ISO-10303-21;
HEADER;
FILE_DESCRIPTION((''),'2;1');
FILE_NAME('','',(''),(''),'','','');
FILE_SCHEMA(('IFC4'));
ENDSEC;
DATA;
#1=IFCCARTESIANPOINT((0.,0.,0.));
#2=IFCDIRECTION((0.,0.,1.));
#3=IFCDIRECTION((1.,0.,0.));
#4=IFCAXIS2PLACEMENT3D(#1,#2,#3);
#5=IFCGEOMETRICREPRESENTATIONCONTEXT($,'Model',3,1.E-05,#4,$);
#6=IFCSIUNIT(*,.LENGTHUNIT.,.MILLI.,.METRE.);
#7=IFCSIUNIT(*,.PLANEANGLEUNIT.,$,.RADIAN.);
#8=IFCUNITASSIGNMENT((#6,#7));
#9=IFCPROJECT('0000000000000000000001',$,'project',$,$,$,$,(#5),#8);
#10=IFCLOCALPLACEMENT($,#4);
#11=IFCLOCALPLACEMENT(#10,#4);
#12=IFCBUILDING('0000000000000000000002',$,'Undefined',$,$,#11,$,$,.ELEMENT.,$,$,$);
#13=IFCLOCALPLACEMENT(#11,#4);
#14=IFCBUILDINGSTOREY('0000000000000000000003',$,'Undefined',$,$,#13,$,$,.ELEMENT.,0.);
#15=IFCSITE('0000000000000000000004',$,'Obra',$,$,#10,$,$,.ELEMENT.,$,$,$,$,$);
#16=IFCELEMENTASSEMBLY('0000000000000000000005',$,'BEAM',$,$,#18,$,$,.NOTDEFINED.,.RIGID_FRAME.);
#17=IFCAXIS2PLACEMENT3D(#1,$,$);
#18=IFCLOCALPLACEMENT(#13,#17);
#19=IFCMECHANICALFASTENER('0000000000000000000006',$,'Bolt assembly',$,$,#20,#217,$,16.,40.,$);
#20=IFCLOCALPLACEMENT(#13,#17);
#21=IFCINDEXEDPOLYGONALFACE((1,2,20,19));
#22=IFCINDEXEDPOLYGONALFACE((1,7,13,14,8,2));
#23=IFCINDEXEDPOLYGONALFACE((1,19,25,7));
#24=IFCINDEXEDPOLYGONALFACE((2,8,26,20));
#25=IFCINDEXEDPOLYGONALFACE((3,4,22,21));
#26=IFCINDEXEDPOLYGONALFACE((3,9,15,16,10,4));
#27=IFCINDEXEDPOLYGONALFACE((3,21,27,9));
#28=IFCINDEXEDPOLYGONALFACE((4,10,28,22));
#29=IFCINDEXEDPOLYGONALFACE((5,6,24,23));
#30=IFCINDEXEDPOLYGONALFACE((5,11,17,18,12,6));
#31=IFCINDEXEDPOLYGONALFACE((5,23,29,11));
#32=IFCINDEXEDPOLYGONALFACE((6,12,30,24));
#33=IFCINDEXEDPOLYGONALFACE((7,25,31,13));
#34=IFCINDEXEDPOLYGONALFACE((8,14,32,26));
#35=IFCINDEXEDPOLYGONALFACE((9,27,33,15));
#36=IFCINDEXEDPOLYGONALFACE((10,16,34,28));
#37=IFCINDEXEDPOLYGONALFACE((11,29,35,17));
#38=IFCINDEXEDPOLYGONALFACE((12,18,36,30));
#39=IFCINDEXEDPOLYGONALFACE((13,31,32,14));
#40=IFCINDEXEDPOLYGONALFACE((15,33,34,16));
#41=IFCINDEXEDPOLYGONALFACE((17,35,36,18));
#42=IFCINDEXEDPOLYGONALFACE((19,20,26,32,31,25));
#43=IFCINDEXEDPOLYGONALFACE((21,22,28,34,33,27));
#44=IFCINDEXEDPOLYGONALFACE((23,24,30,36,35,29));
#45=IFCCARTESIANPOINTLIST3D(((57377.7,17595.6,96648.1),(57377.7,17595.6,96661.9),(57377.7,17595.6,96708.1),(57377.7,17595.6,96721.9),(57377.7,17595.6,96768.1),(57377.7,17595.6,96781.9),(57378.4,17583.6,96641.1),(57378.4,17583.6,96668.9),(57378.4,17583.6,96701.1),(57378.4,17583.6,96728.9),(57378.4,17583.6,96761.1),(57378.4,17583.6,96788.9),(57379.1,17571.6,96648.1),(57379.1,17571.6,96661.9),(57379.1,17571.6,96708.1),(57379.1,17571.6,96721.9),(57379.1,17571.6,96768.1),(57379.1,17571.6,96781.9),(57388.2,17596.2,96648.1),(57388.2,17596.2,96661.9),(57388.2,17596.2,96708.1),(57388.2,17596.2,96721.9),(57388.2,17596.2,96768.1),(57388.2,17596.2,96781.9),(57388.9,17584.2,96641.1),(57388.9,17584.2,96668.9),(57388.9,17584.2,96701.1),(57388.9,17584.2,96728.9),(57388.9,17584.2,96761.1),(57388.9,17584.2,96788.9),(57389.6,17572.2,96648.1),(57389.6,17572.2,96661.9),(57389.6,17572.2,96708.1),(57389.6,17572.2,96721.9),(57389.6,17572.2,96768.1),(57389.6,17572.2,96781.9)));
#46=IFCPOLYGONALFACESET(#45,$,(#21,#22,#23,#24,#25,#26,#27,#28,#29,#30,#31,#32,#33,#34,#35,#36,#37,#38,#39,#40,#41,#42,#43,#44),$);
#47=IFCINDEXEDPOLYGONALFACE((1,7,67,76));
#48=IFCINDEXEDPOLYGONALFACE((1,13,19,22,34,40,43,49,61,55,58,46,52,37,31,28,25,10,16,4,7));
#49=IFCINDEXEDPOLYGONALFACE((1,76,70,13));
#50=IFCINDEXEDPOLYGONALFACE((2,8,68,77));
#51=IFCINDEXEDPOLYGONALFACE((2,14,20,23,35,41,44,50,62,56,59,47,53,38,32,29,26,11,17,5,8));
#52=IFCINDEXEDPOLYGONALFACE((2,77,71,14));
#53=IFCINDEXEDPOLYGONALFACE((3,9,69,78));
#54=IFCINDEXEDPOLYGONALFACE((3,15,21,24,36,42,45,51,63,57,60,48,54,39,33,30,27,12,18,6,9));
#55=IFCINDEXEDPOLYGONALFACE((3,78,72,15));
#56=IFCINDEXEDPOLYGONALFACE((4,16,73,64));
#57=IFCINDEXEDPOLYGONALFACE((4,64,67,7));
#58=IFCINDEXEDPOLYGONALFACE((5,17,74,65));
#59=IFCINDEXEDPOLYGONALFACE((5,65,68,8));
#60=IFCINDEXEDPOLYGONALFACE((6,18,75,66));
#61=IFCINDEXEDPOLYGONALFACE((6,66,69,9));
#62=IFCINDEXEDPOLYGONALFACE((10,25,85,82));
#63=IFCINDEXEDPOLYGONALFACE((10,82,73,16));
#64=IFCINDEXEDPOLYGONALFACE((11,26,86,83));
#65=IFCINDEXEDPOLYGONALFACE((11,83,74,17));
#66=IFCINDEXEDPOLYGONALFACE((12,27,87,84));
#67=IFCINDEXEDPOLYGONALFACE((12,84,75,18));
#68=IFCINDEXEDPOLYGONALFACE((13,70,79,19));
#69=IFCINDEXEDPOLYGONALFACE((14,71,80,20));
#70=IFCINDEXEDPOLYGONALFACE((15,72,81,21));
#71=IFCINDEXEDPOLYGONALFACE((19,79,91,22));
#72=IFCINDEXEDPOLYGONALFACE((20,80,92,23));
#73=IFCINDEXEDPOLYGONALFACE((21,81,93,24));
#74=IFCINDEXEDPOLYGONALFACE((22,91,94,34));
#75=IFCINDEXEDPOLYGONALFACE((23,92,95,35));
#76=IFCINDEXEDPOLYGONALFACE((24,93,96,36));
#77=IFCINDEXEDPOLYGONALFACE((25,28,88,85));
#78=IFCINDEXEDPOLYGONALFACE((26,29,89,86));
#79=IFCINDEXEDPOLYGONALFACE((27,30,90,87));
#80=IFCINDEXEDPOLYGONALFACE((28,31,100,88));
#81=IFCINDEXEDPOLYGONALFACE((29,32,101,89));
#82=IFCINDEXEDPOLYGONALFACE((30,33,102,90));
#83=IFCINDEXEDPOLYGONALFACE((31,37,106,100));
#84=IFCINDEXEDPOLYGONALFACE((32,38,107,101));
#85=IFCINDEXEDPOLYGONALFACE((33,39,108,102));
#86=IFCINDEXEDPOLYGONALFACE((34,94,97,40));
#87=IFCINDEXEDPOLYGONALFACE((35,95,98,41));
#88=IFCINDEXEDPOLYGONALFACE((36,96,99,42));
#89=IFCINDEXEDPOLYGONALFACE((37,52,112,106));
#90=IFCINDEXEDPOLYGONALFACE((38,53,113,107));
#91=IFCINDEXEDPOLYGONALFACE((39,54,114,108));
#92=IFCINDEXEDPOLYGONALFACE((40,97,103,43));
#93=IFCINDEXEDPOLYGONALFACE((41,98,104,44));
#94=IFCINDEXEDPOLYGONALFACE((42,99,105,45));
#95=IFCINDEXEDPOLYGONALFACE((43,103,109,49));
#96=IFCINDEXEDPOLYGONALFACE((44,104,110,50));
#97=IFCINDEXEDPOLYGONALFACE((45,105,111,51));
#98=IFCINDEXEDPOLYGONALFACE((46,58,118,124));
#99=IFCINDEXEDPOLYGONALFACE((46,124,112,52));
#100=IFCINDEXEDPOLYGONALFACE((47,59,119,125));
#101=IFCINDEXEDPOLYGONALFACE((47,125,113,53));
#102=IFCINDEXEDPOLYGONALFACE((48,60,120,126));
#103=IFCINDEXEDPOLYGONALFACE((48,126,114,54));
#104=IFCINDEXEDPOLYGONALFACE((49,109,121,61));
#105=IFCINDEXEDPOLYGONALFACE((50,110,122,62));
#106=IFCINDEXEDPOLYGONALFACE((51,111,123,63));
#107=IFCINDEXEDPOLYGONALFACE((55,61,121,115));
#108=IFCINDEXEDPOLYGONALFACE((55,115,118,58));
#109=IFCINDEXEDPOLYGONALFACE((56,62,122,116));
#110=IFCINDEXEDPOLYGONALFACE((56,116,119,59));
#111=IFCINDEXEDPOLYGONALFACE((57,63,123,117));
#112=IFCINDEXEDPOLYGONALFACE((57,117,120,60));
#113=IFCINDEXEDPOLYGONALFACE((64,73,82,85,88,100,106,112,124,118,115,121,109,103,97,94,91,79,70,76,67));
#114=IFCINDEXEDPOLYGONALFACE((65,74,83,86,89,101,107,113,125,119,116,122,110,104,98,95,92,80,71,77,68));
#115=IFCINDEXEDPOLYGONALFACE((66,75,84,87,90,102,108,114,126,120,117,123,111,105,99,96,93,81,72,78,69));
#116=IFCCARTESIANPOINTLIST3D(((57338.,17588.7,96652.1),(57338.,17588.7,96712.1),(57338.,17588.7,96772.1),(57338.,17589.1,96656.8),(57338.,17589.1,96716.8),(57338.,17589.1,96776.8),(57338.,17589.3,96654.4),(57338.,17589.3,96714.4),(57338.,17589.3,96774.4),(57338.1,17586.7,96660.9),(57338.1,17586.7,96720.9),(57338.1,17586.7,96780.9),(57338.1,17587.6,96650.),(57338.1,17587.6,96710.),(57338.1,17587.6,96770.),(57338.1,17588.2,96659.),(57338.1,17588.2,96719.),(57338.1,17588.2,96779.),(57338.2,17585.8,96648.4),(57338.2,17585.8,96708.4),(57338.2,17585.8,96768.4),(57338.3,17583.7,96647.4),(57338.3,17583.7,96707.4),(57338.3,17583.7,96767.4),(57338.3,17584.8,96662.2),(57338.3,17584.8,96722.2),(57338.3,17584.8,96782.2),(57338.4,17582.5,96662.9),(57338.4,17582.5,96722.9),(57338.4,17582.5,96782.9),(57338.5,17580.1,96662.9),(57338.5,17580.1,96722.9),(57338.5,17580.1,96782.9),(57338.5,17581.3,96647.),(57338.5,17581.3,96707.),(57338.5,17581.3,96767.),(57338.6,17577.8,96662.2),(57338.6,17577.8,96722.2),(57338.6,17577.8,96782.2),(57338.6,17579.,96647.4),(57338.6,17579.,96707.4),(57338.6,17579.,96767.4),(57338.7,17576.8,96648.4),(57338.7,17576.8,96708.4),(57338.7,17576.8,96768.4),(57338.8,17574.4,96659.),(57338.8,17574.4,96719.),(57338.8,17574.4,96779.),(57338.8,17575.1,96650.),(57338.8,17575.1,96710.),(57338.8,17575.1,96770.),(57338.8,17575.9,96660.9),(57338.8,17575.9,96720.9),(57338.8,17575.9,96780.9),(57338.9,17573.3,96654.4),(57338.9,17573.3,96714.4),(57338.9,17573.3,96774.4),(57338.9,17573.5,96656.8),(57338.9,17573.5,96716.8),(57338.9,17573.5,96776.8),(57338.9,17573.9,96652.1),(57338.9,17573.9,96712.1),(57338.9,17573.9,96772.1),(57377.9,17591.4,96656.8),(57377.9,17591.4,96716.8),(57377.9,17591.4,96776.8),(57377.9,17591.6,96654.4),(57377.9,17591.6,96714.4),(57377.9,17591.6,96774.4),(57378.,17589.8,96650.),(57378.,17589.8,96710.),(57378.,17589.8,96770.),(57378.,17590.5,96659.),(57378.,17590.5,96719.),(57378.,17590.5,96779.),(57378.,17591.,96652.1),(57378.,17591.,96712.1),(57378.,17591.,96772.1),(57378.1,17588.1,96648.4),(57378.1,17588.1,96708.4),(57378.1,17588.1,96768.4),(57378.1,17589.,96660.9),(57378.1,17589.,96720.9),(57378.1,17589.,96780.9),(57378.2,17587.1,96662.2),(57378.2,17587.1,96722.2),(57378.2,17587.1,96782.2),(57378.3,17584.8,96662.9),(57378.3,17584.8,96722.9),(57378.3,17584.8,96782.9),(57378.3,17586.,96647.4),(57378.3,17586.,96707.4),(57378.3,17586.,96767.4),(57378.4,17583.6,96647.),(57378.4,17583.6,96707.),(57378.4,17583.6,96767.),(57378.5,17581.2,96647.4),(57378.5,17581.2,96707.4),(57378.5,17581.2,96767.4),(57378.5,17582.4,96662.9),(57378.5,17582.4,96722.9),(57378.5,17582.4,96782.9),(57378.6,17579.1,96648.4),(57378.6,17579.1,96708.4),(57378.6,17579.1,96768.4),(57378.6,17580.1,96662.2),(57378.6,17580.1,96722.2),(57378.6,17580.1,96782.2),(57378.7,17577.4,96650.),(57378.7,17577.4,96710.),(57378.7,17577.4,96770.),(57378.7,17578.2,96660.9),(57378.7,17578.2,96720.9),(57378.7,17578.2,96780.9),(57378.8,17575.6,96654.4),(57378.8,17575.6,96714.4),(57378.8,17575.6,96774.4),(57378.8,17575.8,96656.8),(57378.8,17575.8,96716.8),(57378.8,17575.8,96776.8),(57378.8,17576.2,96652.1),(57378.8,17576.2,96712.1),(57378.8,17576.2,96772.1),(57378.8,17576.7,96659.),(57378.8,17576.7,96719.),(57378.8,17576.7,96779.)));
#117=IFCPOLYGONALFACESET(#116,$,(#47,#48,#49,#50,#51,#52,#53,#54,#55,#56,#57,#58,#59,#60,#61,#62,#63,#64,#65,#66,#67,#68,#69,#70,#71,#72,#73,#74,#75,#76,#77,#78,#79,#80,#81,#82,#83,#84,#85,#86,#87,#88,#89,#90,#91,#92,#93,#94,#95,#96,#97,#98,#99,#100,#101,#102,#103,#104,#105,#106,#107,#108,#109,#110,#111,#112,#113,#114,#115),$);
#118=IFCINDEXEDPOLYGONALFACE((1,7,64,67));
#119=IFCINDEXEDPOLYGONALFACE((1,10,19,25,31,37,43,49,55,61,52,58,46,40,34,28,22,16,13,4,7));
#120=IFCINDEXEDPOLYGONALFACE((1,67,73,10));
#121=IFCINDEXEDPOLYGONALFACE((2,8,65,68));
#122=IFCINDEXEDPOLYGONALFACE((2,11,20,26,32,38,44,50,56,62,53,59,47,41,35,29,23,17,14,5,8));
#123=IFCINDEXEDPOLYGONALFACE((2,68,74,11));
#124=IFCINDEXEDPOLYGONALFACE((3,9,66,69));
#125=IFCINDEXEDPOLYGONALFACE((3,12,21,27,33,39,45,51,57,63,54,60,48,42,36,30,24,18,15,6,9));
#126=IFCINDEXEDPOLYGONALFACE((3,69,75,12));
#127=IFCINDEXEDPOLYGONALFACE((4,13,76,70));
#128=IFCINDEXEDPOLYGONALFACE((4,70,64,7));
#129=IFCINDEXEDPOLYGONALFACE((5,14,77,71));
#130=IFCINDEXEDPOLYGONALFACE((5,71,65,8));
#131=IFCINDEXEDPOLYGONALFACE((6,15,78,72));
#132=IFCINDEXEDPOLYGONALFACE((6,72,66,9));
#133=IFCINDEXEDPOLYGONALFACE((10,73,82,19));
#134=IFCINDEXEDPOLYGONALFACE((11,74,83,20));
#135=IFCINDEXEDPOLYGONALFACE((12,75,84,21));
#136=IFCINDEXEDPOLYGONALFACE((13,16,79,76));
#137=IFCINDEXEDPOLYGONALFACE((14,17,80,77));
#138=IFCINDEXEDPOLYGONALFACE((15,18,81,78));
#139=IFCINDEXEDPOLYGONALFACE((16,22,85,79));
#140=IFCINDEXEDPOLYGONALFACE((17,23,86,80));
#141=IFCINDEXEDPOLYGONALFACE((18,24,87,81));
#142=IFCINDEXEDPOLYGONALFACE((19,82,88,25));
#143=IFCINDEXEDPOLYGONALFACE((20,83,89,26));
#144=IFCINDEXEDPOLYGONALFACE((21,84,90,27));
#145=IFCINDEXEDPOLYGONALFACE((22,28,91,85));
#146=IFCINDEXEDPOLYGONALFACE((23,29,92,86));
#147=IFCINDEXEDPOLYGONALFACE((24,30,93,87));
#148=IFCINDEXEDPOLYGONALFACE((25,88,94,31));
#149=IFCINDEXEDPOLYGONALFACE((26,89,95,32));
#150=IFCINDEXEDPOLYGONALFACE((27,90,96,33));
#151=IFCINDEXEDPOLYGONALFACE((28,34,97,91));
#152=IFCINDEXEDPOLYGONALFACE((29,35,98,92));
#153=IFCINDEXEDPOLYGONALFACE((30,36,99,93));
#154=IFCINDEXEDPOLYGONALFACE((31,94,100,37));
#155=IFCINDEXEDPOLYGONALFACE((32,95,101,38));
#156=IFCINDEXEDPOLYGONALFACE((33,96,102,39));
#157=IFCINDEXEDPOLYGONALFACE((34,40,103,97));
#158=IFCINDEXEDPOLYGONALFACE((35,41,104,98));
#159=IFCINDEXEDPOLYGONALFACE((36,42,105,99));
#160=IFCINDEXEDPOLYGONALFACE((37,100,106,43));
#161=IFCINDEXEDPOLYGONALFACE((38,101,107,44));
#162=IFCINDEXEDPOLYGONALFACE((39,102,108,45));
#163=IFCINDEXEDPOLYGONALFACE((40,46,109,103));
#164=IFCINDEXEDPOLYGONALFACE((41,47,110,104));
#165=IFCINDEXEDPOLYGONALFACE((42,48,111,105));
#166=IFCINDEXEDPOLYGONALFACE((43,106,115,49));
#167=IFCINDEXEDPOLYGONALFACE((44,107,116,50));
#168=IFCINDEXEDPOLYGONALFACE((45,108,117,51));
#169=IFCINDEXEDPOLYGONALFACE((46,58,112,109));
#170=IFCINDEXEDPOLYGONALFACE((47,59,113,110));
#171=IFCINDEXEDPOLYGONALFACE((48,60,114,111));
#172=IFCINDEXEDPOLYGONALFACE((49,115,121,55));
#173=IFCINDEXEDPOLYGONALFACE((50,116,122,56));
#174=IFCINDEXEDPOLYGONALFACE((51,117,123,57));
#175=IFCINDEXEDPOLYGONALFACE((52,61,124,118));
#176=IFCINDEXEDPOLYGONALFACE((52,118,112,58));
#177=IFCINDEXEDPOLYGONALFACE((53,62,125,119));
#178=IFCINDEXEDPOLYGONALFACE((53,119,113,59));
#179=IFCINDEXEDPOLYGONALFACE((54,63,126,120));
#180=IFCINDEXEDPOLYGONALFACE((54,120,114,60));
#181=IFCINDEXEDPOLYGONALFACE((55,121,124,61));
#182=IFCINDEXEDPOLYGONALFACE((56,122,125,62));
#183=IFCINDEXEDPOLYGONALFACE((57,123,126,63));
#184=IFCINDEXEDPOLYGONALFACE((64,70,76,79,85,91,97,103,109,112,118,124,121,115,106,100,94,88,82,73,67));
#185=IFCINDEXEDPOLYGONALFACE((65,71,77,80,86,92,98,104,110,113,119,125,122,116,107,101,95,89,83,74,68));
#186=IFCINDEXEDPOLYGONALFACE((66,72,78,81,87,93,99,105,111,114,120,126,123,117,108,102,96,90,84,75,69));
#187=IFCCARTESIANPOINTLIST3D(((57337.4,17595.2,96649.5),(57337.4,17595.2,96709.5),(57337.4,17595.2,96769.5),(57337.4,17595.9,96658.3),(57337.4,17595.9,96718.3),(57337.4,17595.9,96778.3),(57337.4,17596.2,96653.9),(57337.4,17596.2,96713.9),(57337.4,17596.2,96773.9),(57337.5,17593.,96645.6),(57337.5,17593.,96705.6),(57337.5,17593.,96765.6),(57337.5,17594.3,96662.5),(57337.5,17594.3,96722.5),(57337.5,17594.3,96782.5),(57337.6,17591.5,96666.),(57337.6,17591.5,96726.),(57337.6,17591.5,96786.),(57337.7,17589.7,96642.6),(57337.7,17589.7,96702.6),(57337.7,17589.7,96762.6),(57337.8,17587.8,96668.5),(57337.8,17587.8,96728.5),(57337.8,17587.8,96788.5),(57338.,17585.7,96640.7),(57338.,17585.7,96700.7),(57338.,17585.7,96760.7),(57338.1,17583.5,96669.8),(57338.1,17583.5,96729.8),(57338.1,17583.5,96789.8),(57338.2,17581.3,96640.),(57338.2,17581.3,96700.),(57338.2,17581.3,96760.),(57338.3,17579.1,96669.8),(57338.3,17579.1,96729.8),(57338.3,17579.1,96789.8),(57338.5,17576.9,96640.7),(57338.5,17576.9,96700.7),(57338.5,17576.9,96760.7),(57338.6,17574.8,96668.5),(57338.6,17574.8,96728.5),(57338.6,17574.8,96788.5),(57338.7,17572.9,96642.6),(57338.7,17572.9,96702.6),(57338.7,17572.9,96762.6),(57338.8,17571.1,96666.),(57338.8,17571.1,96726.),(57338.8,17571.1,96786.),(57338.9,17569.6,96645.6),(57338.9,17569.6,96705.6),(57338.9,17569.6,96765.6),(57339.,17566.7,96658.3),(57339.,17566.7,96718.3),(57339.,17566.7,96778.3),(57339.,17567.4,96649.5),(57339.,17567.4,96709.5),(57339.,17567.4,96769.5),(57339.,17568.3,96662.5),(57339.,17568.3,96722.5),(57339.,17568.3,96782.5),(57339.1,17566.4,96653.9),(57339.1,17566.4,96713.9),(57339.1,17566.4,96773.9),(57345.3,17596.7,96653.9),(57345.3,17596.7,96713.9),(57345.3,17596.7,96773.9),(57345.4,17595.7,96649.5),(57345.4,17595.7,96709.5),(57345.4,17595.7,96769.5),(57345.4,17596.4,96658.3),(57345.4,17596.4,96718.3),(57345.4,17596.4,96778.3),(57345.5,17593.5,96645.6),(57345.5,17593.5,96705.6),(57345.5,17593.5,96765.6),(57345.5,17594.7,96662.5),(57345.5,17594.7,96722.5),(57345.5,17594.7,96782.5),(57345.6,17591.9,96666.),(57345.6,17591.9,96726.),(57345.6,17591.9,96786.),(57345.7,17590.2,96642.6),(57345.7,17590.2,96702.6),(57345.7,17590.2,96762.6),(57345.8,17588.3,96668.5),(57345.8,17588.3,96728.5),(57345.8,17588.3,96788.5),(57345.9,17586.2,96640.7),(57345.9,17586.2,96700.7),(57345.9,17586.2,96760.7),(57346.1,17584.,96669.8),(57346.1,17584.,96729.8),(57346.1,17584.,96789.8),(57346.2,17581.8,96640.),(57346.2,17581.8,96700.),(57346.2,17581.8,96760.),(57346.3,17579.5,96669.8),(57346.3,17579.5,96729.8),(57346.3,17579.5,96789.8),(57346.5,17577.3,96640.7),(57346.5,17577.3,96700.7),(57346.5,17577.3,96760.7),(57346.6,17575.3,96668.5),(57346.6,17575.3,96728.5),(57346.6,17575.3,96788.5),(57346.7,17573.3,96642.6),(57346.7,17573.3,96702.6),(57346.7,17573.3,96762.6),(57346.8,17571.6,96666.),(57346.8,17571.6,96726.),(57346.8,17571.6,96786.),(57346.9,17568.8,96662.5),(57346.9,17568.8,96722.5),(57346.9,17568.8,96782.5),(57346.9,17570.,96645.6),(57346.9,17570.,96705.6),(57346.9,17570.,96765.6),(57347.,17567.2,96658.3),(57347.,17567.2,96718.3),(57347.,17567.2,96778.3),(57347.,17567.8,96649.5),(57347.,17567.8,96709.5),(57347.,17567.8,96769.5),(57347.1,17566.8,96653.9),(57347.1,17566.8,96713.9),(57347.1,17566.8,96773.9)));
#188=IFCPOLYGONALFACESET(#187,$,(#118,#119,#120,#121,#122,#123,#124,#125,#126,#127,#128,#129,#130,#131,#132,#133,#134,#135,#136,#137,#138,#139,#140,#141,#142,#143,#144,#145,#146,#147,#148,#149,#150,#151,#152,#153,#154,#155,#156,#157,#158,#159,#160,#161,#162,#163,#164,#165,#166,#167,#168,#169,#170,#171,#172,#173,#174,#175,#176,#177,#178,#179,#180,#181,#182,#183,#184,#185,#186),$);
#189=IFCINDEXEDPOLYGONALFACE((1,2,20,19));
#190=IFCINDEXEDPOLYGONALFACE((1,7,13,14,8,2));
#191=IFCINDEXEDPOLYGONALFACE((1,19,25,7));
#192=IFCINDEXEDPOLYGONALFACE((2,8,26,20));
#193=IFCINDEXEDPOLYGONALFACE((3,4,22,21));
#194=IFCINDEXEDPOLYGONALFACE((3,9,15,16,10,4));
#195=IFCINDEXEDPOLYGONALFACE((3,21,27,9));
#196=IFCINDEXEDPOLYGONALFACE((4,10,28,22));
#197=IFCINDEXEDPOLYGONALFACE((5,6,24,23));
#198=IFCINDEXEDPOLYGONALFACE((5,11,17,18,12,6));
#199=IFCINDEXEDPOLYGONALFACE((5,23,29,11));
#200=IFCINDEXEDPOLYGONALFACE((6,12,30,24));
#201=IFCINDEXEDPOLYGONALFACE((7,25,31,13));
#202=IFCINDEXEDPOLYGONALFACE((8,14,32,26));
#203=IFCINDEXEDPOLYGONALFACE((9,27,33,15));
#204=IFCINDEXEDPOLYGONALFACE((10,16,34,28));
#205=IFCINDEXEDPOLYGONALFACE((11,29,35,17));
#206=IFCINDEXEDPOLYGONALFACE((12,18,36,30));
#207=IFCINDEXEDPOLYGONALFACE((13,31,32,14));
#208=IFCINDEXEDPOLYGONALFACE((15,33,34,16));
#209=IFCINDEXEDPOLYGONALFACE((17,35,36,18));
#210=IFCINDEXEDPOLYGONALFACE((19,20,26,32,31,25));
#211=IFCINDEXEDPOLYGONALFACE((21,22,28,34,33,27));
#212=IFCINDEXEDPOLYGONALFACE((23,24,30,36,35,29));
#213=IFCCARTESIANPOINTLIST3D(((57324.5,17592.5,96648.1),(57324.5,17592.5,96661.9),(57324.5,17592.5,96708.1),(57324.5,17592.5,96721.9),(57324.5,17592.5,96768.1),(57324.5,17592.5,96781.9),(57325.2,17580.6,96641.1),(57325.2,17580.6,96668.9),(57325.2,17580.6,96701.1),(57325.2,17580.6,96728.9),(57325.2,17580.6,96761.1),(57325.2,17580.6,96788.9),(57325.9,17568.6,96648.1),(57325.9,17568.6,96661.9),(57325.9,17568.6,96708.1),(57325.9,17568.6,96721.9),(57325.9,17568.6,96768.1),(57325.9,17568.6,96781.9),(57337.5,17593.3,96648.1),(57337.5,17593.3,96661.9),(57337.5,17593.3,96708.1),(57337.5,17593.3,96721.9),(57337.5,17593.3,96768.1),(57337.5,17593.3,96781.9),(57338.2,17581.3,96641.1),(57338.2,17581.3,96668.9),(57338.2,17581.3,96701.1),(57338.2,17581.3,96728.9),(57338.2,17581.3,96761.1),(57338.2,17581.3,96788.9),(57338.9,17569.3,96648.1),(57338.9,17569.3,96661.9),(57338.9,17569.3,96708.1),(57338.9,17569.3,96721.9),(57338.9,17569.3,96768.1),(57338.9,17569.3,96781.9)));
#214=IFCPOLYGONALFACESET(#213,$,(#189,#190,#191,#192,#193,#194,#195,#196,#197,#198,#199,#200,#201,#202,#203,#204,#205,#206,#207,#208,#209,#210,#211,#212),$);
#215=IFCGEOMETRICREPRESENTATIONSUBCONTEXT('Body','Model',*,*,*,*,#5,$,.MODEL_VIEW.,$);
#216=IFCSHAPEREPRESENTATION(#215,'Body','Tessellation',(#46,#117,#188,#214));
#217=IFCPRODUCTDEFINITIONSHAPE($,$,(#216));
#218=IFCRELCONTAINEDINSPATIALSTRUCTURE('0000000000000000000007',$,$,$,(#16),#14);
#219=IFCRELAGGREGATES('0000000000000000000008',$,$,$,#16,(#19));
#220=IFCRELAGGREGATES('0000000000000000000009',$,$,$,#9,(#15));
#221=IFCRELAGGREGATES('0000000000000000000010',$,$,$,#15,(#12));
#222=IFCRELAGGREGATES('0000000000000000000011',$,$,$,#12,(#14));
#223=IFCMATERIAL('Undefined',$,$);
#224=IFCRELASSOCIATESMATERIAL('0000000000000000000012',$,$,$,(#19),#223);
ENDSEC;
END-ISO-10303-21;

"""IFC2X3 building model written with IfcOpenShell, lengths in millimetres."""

from ifc_helpers import new_model, si_unit, frame, origin_with_axes, origin_2d_with_axis, place, context, subcontext, project, spatial, polyline, circle, outline, extrude, source, transform, mapped, material, element, aggregate, save


model = new_model("IFC2X3")

# Units and contexts
model_context = context("Model", 3, precision=1e-05, world=origin_with_axes())
body_context = subcontext(model_context, "Body", "Model", "MODEL_VIEW")
ifc_project = project(units=[si_unit("LENGTHUNIT", "METRE", prefix="MILLI"), si_unit("PLANEANGLEUNIT", "RADIAN")], contexts=[model_context])

# Site, building, storey
site_placement = place(None, origin_with_axes())
site = spatial("IfcSite", under=ifc_project, at=site_placement, Name="Obra", CompositionType="ELEMENT")
building_placement = place(site_placement, origin_with_axes())
building = spatial("IfcBuilding", under=site, at=building_placement, Name="Undefined", CompositionType="ELEMENT")
storey_placement = place(building_placement, origin_with_axes())
storey = spatial("IfcBuildingStorey", under=building, at=storey_placement, Name="Undefined", CompositionType="ELEMENT", Elevation=0.0)

# Shared definitions
ifc_material_1 = material(Name="Undefined")

# Element assembly, mechanical fastener
shared_shape_1 = source(origin_with_axes(), body_context, "Body", "SweptSolid", [
    extrude(outline(polyline([(13.9, 0.0), (6.9, 12.0), (-6.9, 12.0), (-13.9, 0.0), (-6.9, -12.0), (6.9, -12.0), (13.9, 0.0)])), frame((0.0, -45.9, 0.0), z_axis=(0.0, 1.0, 0.0), x_axis=(1.0, 0.0, 0.0)), (0.0, 0.0, 1.0), 10.6),
    extrude(circle(Radius=8.0, at=origin_2d_with_axis()), frame((0.0, -35.3, 0.0), z_axis=(0.0, 1.0, 0.0), x_axis=(1.0, 0.0, 0.0)), (0.0, 0.0, 1.0), 40.0),
    extrude(circle(Radius=15.0, at=origin_2d_with_axis()), frame((0.0, -3.1, 0.0), z_axis=(0.0, 1.0, 0.0), x_axis=(1.0, 0.0, 0.0)), (0.0, 0.0, 1.0), 8.0),
    extrude(outline(polyline([(13.9, 0.0), (6.9, 12.0), (-6.9, 12.0), (-13.9, 0.0), (-6.9, -12.0), (6.9, -12.0), (13.9, 0.0)])), frame((0.0, 4.9, 0.0), z_axis=(0.0, 1.0, 0.0), x_axis=(1.0, 0.0, 0.0)), (0.0, 0.0, 1.0), 13.0),
])
assembly_1_placement = place(storey_placement, origin_with_axes())
assembly_1 = element("IfcElementAssembly", 1, at=assembly_1_placement, inside=storey, Name="BEAM", AssemblyPlace="NOTDEFINED", PredefinedType="RIGID_FRAME")
mechanical_fastener_1_placement = place(assembly_1_placement, frame((57346.0, 17531.7, 96835.0), z_axis=(-0.057107, 0.998368, 0.0), x_axis=(0.0, 0.0, -1.0)))
mechanical_fastener_1 = element("IfcMechanicalFastener", 2, at=mechanical_fastener_1_placement, material=ifc_material_1, Name="Bolt assembly", NominalDiameter=16.0, NominalLength=40.0, context=body_context, shape_type="MappedRepresentation", body=[
    mapped(shared_shape_1, transform((60.0, 0.0, 50.0))),
    mapped(shared_shape_1, transform((120.0, 0.0, 50.0))),
    mapped(shared_shape_1, transform((180.0, 0.0, 50.0))),
])
aggregate(assembly_1, [mechanical_fastener_1])

save(model, "model.ifc")
